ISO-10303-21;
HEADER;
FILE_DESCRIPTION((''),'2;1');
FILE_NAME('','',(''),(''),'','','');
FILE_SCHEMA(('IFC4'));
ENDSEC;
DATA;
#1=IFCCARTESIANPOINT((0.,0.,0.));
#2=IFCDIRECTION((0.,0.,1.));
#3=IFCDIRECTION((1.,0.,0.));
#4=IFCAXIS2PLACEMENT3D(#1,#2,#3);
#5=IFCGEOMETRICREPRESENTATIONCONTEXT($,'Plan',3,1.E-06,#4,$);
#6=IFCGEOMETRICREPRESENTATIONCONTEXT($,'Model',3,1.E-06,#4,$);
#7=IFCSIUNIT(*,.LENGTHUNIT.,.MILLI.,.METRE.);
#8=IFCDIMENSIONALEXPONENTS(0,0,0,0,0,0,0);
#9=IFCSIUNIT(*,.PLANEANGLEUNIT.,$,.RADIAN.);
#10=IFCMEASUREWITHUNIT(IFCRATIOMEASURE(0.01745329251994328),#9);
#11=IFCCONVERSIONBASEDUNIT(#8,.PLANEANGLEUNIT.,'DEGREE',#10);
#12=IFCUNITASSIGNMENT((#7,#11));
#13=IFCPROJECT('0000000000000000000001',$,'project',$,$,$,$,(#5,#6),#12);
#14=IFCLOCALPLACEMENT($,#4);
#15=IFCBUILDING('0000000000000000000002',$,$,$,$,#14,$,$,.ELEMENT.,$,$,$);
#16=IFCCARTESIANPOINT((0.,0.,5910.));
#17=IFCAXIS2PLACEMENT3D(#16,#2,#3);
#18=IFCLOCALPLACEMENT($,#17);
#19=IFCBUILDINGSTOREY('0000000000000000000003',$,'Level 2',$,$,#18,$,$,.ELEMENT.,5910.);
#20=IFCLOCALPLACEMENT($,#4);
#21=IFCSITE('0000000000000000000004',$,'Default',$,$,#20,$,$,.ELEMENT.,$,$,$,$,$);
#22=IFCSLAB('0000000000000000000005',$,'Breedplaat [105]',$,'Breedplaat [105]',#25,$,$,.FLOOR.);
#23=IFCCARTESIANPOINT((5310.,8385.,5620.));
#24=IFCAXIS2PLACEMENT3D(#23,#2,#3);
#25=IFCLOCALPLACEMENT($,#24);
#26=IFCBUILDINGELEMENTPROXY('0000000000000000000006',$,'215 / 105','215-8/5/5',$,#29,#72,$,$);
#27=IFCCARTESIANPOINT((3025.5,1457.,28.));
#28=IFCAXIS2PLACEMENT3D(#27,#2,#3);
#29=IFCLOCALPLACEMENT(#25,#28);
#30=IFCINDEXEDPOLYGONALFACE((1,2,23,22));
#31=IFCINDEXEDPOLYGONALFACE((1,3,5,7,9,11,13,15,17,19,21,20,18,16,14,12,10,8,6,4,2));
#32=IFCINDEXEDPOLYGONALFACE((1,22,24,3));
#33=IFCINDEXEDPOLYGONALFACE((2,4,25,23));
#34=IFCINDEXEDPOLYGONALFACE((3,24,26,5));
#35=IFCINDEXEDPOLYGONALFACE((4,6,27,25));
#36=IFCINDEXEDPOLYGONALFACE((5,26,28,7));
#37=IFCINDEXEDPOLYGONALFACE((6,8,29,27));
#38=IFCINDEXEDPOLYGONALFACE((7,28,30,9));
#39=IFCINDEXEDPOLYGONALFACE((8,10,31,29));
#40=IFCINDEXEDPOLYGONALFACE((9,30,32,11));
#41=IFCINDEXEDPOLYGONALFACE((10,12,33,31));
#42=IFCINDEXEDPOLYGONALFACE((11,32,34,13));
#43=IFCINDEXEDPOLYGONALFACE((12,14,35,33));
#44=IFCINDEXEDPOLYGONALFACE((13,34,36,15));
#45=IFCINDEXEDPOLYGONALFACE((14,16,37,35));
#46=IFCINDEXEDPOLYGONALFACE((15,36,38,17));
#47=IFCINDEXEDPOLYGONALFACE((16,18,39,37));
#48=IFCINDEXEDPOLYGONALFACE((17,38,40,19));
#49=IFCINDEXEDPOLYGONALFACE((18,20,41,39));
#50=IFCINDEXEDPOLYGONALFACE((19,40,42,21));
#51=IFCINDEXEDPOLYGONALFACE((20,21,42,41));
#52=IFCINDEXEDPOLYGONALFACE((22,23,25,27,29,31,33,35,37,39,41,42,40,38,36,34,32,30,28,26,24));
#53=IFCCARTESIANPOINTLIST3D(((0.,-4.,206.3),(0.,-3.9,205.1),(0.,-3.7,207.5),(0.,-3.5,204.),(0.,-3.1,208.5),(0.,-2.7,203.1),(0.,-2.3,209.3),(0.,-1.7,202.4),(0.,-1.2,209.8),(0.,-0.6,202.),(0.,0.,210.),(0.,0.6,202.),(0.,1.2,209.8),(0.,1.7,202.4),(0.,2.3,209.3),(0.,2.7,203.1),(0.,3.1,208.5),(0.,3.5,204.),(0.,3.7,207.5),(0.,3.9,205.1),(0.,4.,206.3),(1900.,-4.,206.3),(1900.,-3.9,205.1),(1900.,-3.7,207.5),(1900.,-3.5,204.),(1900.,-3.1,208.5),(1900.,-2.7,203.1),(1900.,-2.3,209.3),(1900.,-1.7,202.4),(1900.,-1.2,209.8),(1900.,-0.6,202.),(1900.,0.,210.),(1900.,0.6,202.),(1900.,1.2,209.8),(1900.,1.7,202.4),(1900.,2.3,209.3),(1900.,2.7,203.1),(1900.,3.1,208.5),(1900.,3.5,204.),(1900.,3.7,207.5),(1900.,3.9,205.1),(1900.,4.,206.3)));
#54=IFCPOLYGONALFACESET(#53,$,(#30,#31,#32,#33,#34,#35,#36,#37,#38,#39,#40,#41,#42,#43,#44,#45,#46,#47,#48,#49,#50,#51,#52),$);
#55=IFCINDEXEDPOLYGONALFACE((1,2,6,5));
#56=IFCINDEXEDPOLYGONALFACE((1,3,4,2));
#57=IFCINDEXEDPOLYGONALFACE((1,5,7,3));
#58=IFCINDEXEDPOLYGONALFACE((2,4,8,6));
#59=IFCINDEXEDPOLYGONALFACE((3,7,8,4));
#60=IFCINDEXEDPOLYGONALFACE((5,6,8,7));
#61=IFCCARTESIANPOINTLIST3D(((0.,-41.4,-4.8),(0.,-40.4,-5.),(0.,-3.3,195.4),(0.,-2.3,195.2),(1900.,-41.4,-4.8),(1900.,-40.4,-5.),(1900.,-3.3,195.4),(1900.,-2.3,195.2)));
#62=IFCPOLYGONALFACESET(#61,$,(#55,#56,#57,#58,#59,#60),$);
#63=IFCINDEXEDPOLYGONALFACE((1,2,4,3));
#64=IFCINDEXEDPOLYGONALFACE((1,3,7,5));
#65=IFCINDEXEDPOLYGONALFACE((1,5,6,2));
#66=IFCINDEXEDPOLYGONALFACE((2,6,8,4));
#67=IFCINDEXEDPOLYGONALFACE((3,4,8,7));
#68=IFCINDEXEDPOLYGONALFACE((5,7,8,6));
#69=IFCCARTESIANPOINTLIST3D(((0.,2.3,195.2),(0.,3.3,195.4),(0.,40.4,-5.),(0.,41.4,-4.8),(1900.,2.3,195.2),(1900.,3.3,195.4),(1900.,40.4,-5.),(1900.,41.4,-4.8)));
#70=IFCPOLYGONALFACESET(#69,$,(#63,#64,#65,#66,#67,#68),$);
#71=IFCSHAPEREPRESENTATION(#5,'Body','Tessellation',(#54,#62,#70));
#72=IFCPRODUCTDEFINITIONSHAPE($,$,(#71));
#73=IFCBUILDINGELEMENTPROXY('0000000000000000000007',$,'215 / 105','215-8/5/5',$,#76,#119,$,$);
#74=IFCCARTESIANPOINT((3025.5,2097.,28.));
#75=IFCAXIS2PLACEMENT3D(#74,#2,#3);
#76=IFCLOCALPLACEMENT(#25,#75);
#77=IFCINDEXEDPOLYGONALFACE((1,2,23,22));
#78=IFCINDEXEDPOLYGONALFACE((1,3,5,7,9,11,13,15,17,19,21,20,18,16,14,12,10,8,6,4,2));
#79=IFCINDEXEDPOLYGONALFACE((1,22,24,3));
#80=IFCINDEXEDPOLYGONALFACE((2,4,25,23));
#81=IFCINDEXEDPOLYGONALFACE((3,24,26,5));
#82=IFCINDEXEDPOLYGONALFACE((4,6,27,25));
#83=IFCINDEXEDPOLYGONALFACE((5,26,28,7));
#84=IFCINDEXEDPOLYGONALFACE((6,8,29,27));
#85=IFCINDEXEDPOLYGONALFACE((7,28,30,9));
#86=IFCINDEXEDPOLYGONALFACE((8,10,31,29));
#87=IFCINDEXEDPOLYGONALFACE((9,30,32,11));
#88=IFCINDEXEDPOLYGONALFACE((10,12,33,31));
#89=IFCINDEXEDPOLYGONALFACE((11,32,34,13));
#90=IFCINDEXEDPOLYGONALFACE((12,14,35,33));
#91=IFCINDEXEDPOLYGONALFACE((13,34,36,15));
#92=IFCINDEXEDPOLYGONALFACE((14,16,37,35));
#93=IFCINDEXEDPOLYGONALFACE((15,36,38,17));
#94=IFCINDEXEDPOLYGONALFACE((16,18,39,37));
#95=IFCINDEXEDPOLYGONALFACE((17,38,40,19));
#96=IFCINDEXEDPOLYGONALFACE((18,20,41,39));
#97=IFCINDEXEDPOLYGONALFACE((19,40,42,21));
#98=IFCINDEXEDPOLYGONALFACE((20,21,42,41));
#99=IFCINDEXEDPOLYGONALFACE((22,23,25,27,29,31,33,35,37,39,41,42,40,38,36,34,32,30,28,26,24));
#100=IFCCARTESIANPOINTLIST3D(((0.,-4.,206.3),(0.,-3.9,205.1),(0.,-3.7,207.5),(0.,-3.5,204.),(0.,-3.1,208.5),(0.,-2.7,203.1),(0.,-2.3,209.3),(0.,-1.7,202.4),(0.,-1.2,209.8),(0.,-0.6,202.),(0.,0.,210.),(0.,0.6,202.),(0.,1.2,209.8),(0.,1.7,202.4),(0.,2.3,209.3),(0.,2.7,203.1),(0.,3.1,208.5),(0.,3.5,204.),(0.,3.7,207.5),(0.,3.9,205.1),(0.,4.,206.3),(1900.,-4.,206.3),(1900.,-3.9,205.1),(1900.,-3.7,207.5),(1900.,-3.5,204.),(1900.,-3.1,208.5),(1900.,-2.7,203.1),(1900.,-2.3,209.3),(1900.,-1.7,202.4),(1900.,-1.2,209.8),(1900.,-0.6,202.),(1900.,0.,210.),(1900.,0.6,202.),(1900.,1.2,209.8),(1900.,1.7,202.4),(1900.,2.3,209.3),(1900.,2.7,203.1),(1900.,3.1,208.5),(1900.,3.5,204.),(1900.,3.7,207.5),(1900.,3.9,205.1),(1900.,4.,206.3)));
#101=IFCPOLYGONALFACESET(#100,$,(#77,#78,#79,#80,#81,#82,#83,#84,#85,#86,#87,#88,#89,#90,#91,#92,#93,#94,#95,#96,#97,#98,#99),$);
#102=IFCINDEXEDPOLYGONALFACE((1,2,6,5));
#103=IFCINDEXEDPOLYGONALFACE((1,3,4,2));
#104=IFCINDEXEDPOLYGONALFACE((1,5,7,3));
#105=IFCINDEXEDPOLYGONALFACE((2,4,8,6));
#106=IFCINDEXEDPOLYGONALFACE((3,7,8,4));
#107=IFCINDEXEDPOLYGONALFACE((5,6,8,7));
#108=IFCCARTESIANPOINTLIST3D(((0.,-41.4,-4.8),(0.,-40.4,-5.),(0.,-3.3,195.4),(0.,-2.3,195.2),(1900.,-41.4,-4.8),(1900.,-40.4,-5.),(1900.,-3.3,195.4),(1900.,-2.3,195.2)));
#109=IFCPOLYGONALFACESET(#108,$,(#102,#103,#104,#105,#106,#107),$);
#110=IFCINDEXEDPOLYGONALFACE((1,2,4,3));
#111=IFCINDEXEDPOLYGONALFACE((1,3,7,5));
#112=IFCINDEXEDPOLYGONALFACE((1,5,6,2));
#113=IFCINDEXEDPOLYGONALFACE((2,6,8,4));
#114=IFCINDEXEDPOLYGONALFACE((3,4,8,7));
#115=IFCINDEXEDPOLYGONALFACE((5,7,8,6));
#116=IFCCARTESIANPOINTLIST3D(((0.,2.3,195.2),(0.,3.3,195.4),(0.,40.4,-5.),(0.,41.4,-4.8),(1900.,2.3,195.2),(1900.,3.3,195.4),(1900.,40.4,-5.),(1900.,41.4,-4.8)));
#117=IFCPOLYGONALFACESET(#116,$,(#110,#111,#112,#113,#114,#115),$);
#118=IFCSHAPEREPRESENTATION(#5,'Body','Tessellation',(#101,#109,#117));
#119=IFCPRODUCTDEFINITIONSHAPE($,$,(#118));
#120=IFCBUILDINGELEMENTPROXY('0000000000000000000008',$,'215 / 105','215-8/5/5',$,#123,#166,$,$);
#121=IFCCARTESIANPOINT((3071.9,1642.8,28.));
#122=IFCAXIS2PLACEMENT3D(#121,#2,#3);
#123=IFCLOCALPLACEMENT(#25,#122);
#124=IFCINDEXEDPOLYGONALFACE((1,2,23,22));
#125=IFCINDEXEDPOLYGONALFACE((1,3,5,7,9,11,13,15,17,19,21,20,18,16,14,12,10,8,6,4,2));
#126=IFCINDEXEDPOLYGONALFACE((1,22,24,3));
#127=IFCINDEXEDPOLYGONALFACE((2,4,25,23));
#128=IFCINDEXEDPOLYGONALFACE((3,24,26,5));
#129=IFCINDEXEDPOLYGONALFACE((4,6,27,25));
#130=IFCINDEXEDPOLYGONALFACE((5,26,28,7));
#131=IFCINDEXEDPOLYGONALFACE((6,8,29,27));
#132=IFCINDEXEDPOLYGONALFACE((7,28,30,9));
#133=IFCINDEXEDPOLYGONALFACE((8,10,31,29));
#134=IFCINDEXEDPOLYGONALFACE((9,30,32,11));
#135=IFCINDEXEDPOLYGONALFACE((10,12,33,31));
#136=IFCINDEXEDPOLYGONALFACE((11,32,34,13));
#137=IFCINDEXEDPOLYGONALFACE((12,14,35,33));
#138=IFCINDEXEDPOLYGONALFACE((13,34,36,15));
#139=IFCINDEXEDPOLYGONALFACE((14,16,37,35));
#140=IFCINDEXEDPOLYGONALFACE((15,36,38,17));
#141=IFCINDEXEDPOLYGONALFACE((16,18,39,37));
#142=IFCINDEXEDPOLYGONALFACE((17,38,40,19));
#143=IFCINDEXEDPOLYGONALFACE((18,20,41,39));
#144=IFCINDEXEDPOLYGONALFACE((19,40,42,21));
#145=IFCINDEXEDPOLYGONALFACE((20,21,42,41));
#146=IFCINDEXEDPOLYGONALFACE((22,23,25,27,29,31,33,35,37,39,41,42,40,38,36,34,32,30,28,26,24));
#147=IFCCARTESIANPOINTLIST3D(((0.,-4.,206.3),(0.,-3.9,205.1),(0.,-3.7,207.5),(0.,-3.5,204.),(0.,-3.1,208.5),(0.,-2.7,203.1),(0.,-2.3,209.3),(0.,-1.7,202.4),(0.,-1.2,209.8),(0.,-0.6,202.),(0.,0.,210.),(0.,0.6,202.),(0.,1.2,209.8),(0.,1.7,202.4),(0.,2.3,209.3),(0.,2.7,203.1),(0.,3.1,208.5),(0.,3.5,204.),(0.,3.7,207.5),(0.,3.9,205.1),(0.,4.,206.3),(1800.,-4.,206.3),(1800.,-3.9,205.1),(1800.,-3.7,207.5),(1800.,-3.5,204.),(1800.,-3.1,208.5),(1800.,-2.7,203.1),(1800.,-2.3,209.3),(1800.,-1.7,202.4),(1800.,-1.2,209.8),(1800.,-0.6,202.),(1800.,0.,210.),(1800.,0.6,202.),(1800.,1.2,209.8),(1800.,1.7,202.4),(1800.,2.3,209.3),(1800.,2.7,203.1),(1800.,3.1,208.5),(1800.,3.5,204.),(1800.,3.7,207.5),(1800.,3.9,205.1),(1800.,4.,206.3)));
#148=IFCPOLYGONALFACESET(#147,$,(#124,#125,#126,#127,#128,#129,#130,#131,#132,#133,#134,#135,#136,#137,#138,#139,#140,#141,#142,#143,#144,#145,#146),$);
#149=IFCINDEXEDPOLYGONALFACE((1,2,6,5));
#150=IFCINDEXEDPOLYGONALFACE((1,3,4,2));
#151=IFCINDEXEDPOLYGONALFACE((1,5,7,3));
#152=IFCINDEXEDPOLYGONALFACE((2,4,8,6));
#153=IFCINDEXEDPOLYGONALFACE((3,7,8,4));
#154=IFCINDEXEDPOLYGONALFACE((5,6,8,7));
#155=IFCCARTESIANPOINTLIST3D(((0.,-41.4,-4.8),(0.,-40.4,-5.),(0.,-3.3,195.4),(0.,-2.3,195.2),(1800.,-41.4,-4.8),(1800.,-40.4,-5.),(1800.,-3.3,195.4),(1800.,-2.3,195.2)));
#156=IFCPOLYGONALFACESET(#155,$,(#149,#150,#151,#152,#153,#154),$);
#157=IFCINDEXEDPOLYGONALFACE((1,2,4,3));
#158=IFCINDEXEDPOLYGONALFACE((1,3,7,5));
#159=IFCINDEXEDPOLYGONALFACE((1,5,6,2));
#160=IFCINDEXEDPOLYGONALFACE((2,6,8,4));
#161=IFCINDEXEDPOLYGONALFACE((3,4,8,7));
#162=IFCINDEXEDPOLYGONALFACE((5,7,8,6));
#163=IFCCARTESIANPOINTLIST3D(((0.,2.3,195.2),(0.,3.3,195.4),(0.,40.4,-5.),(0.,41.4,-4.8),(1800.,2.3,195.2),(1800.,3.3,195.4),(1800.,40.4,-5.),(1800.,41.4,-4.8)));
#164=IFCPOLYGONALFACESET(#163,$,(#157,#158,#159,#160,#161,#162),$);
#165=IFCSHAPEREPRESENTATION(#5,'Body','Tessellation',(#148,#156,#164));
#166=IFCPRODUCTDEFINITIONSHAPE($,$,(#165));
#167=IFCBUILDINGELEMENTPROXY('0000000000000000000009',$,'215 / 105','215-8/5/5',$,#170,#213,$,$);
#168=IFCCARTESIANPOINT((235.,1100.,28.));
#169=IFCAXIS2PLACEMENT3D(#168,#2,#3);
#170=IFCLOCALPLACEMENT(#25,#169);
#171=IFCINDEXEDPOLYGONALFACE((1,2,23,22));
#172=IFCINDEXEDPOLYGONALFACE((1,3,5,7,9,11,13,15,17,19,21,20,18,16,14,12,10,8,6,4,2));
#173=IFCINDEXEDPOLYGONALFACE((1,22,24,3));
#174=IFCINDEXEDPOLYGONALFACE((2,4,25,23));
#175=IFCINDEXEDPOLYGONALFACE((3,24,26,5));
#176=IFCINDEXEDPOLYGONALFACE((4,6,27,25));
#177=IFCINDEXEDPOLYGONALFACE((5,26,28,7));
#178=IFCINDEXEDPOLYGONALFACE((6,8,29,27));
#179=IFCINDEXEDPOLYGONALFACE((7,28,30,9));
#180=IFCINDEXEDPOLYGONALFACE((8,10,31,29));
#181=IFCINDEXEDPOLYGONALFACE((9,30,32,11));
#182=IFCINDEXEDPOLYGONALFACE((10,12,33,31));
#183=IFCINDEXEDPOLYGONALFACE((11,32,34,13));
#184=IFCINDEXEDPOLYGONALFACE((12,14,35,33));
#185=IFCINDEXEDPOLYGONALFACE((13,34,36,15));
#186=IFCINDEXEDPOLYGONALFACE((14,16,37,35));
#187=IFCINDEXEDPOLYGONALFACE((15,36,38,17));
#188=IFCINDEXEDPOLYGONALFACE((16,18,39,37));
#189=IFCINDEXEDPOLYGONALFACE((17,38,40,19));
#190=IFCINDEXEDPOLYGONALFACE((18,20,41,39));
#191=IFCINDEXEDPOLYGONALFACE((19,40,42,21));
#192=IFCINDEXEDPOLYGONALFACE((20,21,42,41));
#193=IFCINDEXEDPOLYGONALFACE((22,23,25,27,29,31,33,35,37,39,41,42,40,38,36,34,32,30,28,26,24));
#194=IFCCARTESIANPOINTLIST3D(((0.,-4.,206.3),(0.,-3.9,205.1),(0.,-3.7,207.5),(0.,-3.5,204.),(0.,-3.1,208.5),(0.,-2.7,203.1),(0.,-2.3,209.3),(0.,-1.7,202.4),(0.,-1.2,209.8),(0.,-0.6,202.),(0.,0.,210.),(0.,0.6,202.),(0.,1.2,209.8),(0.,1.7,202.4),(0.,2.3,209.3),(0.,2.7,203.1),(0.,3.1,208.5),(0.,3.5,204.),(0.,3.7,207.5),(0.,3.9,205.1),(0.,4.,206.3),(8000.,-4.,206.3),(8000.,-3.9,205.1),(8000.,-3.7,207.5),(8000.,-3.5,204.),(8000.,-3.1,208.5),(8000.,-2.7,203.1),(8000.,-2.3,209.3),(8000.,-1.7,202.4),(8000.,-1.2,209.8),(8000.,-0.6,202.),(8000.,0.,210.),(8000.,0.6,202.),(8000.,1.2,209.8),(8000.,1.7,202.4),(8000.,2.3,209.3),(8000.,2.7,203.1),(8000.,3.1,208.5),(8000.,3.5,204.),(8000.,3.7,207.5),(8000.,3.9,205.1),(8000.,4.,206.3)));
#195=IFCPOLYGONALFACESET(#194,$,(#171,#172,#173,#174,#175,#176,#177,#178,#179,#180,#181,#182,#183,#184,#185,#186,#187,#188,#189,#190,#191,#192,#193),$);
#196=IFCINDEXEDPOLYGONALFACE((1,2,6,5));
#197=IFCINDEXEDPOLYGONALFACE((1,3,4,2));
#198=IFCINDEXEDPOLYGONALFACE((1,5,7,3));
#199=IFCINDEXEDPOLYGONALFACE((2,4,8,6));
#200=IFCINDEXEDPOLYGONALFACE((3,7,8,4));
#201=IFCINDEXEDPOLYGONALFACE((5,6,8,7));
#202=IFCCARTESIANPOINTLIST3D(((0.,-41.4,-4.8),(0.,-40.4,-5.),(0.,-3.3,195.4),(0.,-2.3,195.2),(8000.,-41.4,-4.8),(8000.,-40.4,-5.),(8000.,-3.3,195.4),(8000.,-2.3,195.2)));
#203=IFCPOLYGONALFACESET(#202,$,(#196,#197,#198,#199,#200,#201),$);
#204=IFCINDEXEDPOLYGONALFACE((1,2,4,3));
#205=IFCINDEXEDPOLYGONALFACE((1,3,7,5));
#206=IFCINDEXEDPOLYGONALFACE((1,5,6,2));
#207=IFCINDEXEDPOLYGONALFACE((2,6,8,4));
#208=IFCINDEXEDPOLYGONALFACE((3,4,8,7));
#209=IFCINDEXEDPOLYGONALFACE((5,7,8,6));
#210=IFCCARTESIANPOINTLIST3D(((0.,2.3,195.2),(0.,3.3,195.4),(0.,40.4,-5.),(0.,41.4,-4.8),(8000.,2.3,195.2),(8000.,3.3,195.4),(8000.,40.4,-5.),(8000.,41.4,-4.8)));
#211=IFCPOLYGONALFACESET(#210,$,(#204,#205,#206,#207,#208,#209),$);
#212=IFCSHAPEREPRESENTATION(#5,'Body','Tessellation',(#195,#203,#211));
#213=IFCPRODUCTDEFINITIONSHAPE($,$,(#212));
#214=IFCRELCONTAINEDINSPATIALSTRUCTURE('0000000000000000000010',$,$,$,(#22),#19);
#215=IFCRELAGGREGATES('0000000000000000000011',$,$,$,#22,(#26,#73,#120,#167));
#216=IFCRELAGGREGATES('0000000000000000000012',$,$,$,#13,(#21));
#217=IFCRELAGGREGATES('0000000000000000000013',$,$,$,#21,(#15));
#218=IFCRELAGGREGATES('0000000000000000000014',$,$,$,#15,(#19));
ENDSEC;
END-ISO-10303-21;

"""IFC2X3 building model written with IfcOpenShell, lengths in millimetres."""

from ifc_helpers import new_model, entity, si_unit, converted_unit, frame, origin_with_axes, origin_2d_with_axis, place, context, project, spatial, rectangle, circle, extrude, element, aggregate, save


model = new_model("IFC2X3")

# Units and contexts
plan_context = context("Plan", 3, precision=1e-06, world=origin_with_axes())
model_context = context("Model", 3, precision=1e-06, world=origin_with_axes())
ifc_project = project(units=[si_unit("LENGTHUNIT", "METRE", prefix="MILLI"), converted_unit("PLANEANGLEUNIT", "DEGREE", entity("IfcRatioMeasure", 0.01745329251994328), si_unit("PLANEANGLEUNIT", "RADIAN"), dimensions=[0, 0, 0, 0, 0, 0, 0])], contexts=[plan_context, model_context])

# Site, building, storey
site_placement = place(None, origin_with_axes())
site = spatial("IfcSite", under=ifc_project, at=site_placement, Name="Default", CompositionType="ELEMENT")
building_placement = place(None, origin_with_axes())
building = spatial("IfcBuilding", under=site, at=building_placement, CompositionType="ELEMENT")
storey_placement = place(None, frame((0.0, 0.0, 5910.0), z_axis=(0.0, 0.0, 1.0), x_axis=(1.0, 0.0, 0.0)))
storey = spatial("IfcBuildingStorey", under=building, at=storey_placement, Name="Level 2", CompositionType="ELEMENT", Elevation=5910.0)

# Slab, building element proxies
slab_1_placement = place(None, frame((5310.0, 8385.0, 5620.0), z_axis=(0.0, 0.0, 1.0), x_axis=(1.0, 0.0, 0.0)))
slab_1 = element("IfcSlab", 1, at=slab_1_placement, inside=storey, Name="Breedplaat [105]", ObjectType="Breedplaat [105]", PredefinedType="FLOOR")
proxy_1_placement = place(slab_1_placement, frame((3025.5, 1457.0, 28.0), z_axis=(0.0, 0.0, 1.0), x_axis=(1.0, 0.0, 0.0)))
proxy_1 = element("IfcBuildingElementProxy", 2, at=proxy_1_placement, Name="215 / 105", Description="215-8/5/5", context=plan_context, shape_type="SweptSolid", body=[
    extrude(circle(Radius=4.0, at=origin_2d_with_axis()), frame((0.0, 0.0, 206.0), z_axis=(1.0, 0.0, 0.0), x_axis=(0.0, 0.0, 1.0)), (0.0, 0.0, 1.0), 1900.0),
    extrude(rectangle(XDim=203.8, YDim=1.0, at=origin_2d_with_axis()), frame((0.0, -21.9, 95.2), z_axis=(1.0, 0.0, 0.0), x_axis=(0.0, 0.187112, 0.982339)), (0.0, 0.0, 1.0), 1900.0),
    extrude(rectangle(XDim=203.8, YDim=1.0, at=origin_2d_with_axis()), frame((0.0, 21.9, 95.2), z_axis=(1.0, 0.0, 0.0), x_axis=(0.0, -0.187112, 0.982339)), (0.0, 0.0, 1.0), 1900.0),
])
proxy_2_placement = place(slab_1_placement, frame((3025.5, 2097.0, 28.0), z_axis=(0.0, 0.0, 1.0), x_axis=(1.0, 0.0, 0.0)))
proxy_2 = element("IfcBuildingElementProxy", 3, at=proxy_2_placement, Name="215 / 105", Description="215-8/5/5", context=plan_context, shape_type="SweptSolid", body=[
    extrude(circle(Radius=4.0, at=origin_2d_with_axis()), frame((0.0, 0.0, 206.0), z_axis=(1.0, 0.0, 0.0), x_axis=(0.0, 0.0, 1.0)), (0.0, 0.0, 1.0), 1900.0),
    extrude(rectangle(XDim=203.8, YDim=1.0, at=origin_2d_with_axis()), frame((0.0, -21.9, 95.2), z_axis=(1.0, 0.0, 0.0), x_axis=(0.0, 0.187112, 0.982339)), (0.0, 0.0, 1.0), 1900.0),
    extrude(rectangle(XDim=203.8, YDim=1.0, at=origin_2d_with_axis()), frame((0.0, 21.9, 95.2), z_axis=(1.0, 0.0, 0.0), x_axis=(0.0, -0.187112, 0.982339)), (0.0, 0.0, 1.0), 1900.0),
])
proxy_3_placement = place(slab_1_placement, frame((3071.9, 1642.8, 28.0), z_axis=(0.0, 0.0, 1.0), x_axis=(1.0, 0.0, 0.0)))
proxy_3 = element("IfcBuildingElementProxy", 4, at=proxy_3_placement, Name="215 / 105", Description="215-8/5/5", context=plan_context, shape_type="SweptSolid", body=[
    extrude(circle(Radius=4.0, at=origin_2d_with_axis()), frame((0.0, 0.0, 206.0), z_axis=(1.0, 0.0, 0.0), x_axis=(0.0, 0.0, 1.0)), (0.0, 0.0, 1.0), 1800.0),
    extrude(rectangle(XDim=203.8, YDim=1.0, at=origin_2d_with_axis()), frame((0.0, -21.9, 95.2), z_axis=(1.0, 0.0, 0.0), x_axis=(0.0, 0.187112, 0.982339)), (0.0, 0.0, 1.0), 1800.0),
    extrude(rectangle(XDim=203.8, YDim=1.0, at=origin_2d_with_axis()), frame((0.0, 21.9, 95.2), z_axis=(1.0, 0.0, 0.0), x_axis=(0.0, -0.187112, 0.982339)), (0.0, 0.0, 1.0), 1800.0),
])
proxy_4_placement = place(slab_1_placement, frame((235.0, 1100.0, 28.0), z_axis=(0.0, 0.0, 1.0), x_axis=(1.0, 0.0, 0.0)))
proxy_4 = element("IfcBuildingElementProxy", 5, at=proxy_4_placement, Name="215 / 105", Description="215-8/5/5", context=plan_context, shape_type="SweptSolid", body=[
    extrude(circle(Radius=4.0, at=origin_2d_with_axis()), frame((0.0, 0.0, 206.0), z_axis=(1.0, 0.0, 0.0), x_axis=(0.0, 0.0, 1.0)), (0.0, 0.0, 1.0), 8000.0),
    extrude(rectangle(XDim=203.8, YDim=1.0, at=origin_2d_with_axis()), frame((0.0, -21.9, 95.2), z_axis=(1.0, 0.0, 0.0), x_axis=(0.0, 0.187112, 0.982339)), (0.0, 0.0, 1.0), 8000.0),
    extrude(rectangle(XDim=203.8, YDim=1.0, at=origin_2d_with_axis()), frame((0.0, 21.9, 95.2), z_axis=(1.0, 0.0, 0.0), x_axis=(0.0, -0.187112, 0.982339)), (0.0, 0.0, 1.0), 8000.0),
])
aggregate(slab_1, [proxy_1, proxy_2, proxy_3, proxy_4])

save(model, "model.ifc")
